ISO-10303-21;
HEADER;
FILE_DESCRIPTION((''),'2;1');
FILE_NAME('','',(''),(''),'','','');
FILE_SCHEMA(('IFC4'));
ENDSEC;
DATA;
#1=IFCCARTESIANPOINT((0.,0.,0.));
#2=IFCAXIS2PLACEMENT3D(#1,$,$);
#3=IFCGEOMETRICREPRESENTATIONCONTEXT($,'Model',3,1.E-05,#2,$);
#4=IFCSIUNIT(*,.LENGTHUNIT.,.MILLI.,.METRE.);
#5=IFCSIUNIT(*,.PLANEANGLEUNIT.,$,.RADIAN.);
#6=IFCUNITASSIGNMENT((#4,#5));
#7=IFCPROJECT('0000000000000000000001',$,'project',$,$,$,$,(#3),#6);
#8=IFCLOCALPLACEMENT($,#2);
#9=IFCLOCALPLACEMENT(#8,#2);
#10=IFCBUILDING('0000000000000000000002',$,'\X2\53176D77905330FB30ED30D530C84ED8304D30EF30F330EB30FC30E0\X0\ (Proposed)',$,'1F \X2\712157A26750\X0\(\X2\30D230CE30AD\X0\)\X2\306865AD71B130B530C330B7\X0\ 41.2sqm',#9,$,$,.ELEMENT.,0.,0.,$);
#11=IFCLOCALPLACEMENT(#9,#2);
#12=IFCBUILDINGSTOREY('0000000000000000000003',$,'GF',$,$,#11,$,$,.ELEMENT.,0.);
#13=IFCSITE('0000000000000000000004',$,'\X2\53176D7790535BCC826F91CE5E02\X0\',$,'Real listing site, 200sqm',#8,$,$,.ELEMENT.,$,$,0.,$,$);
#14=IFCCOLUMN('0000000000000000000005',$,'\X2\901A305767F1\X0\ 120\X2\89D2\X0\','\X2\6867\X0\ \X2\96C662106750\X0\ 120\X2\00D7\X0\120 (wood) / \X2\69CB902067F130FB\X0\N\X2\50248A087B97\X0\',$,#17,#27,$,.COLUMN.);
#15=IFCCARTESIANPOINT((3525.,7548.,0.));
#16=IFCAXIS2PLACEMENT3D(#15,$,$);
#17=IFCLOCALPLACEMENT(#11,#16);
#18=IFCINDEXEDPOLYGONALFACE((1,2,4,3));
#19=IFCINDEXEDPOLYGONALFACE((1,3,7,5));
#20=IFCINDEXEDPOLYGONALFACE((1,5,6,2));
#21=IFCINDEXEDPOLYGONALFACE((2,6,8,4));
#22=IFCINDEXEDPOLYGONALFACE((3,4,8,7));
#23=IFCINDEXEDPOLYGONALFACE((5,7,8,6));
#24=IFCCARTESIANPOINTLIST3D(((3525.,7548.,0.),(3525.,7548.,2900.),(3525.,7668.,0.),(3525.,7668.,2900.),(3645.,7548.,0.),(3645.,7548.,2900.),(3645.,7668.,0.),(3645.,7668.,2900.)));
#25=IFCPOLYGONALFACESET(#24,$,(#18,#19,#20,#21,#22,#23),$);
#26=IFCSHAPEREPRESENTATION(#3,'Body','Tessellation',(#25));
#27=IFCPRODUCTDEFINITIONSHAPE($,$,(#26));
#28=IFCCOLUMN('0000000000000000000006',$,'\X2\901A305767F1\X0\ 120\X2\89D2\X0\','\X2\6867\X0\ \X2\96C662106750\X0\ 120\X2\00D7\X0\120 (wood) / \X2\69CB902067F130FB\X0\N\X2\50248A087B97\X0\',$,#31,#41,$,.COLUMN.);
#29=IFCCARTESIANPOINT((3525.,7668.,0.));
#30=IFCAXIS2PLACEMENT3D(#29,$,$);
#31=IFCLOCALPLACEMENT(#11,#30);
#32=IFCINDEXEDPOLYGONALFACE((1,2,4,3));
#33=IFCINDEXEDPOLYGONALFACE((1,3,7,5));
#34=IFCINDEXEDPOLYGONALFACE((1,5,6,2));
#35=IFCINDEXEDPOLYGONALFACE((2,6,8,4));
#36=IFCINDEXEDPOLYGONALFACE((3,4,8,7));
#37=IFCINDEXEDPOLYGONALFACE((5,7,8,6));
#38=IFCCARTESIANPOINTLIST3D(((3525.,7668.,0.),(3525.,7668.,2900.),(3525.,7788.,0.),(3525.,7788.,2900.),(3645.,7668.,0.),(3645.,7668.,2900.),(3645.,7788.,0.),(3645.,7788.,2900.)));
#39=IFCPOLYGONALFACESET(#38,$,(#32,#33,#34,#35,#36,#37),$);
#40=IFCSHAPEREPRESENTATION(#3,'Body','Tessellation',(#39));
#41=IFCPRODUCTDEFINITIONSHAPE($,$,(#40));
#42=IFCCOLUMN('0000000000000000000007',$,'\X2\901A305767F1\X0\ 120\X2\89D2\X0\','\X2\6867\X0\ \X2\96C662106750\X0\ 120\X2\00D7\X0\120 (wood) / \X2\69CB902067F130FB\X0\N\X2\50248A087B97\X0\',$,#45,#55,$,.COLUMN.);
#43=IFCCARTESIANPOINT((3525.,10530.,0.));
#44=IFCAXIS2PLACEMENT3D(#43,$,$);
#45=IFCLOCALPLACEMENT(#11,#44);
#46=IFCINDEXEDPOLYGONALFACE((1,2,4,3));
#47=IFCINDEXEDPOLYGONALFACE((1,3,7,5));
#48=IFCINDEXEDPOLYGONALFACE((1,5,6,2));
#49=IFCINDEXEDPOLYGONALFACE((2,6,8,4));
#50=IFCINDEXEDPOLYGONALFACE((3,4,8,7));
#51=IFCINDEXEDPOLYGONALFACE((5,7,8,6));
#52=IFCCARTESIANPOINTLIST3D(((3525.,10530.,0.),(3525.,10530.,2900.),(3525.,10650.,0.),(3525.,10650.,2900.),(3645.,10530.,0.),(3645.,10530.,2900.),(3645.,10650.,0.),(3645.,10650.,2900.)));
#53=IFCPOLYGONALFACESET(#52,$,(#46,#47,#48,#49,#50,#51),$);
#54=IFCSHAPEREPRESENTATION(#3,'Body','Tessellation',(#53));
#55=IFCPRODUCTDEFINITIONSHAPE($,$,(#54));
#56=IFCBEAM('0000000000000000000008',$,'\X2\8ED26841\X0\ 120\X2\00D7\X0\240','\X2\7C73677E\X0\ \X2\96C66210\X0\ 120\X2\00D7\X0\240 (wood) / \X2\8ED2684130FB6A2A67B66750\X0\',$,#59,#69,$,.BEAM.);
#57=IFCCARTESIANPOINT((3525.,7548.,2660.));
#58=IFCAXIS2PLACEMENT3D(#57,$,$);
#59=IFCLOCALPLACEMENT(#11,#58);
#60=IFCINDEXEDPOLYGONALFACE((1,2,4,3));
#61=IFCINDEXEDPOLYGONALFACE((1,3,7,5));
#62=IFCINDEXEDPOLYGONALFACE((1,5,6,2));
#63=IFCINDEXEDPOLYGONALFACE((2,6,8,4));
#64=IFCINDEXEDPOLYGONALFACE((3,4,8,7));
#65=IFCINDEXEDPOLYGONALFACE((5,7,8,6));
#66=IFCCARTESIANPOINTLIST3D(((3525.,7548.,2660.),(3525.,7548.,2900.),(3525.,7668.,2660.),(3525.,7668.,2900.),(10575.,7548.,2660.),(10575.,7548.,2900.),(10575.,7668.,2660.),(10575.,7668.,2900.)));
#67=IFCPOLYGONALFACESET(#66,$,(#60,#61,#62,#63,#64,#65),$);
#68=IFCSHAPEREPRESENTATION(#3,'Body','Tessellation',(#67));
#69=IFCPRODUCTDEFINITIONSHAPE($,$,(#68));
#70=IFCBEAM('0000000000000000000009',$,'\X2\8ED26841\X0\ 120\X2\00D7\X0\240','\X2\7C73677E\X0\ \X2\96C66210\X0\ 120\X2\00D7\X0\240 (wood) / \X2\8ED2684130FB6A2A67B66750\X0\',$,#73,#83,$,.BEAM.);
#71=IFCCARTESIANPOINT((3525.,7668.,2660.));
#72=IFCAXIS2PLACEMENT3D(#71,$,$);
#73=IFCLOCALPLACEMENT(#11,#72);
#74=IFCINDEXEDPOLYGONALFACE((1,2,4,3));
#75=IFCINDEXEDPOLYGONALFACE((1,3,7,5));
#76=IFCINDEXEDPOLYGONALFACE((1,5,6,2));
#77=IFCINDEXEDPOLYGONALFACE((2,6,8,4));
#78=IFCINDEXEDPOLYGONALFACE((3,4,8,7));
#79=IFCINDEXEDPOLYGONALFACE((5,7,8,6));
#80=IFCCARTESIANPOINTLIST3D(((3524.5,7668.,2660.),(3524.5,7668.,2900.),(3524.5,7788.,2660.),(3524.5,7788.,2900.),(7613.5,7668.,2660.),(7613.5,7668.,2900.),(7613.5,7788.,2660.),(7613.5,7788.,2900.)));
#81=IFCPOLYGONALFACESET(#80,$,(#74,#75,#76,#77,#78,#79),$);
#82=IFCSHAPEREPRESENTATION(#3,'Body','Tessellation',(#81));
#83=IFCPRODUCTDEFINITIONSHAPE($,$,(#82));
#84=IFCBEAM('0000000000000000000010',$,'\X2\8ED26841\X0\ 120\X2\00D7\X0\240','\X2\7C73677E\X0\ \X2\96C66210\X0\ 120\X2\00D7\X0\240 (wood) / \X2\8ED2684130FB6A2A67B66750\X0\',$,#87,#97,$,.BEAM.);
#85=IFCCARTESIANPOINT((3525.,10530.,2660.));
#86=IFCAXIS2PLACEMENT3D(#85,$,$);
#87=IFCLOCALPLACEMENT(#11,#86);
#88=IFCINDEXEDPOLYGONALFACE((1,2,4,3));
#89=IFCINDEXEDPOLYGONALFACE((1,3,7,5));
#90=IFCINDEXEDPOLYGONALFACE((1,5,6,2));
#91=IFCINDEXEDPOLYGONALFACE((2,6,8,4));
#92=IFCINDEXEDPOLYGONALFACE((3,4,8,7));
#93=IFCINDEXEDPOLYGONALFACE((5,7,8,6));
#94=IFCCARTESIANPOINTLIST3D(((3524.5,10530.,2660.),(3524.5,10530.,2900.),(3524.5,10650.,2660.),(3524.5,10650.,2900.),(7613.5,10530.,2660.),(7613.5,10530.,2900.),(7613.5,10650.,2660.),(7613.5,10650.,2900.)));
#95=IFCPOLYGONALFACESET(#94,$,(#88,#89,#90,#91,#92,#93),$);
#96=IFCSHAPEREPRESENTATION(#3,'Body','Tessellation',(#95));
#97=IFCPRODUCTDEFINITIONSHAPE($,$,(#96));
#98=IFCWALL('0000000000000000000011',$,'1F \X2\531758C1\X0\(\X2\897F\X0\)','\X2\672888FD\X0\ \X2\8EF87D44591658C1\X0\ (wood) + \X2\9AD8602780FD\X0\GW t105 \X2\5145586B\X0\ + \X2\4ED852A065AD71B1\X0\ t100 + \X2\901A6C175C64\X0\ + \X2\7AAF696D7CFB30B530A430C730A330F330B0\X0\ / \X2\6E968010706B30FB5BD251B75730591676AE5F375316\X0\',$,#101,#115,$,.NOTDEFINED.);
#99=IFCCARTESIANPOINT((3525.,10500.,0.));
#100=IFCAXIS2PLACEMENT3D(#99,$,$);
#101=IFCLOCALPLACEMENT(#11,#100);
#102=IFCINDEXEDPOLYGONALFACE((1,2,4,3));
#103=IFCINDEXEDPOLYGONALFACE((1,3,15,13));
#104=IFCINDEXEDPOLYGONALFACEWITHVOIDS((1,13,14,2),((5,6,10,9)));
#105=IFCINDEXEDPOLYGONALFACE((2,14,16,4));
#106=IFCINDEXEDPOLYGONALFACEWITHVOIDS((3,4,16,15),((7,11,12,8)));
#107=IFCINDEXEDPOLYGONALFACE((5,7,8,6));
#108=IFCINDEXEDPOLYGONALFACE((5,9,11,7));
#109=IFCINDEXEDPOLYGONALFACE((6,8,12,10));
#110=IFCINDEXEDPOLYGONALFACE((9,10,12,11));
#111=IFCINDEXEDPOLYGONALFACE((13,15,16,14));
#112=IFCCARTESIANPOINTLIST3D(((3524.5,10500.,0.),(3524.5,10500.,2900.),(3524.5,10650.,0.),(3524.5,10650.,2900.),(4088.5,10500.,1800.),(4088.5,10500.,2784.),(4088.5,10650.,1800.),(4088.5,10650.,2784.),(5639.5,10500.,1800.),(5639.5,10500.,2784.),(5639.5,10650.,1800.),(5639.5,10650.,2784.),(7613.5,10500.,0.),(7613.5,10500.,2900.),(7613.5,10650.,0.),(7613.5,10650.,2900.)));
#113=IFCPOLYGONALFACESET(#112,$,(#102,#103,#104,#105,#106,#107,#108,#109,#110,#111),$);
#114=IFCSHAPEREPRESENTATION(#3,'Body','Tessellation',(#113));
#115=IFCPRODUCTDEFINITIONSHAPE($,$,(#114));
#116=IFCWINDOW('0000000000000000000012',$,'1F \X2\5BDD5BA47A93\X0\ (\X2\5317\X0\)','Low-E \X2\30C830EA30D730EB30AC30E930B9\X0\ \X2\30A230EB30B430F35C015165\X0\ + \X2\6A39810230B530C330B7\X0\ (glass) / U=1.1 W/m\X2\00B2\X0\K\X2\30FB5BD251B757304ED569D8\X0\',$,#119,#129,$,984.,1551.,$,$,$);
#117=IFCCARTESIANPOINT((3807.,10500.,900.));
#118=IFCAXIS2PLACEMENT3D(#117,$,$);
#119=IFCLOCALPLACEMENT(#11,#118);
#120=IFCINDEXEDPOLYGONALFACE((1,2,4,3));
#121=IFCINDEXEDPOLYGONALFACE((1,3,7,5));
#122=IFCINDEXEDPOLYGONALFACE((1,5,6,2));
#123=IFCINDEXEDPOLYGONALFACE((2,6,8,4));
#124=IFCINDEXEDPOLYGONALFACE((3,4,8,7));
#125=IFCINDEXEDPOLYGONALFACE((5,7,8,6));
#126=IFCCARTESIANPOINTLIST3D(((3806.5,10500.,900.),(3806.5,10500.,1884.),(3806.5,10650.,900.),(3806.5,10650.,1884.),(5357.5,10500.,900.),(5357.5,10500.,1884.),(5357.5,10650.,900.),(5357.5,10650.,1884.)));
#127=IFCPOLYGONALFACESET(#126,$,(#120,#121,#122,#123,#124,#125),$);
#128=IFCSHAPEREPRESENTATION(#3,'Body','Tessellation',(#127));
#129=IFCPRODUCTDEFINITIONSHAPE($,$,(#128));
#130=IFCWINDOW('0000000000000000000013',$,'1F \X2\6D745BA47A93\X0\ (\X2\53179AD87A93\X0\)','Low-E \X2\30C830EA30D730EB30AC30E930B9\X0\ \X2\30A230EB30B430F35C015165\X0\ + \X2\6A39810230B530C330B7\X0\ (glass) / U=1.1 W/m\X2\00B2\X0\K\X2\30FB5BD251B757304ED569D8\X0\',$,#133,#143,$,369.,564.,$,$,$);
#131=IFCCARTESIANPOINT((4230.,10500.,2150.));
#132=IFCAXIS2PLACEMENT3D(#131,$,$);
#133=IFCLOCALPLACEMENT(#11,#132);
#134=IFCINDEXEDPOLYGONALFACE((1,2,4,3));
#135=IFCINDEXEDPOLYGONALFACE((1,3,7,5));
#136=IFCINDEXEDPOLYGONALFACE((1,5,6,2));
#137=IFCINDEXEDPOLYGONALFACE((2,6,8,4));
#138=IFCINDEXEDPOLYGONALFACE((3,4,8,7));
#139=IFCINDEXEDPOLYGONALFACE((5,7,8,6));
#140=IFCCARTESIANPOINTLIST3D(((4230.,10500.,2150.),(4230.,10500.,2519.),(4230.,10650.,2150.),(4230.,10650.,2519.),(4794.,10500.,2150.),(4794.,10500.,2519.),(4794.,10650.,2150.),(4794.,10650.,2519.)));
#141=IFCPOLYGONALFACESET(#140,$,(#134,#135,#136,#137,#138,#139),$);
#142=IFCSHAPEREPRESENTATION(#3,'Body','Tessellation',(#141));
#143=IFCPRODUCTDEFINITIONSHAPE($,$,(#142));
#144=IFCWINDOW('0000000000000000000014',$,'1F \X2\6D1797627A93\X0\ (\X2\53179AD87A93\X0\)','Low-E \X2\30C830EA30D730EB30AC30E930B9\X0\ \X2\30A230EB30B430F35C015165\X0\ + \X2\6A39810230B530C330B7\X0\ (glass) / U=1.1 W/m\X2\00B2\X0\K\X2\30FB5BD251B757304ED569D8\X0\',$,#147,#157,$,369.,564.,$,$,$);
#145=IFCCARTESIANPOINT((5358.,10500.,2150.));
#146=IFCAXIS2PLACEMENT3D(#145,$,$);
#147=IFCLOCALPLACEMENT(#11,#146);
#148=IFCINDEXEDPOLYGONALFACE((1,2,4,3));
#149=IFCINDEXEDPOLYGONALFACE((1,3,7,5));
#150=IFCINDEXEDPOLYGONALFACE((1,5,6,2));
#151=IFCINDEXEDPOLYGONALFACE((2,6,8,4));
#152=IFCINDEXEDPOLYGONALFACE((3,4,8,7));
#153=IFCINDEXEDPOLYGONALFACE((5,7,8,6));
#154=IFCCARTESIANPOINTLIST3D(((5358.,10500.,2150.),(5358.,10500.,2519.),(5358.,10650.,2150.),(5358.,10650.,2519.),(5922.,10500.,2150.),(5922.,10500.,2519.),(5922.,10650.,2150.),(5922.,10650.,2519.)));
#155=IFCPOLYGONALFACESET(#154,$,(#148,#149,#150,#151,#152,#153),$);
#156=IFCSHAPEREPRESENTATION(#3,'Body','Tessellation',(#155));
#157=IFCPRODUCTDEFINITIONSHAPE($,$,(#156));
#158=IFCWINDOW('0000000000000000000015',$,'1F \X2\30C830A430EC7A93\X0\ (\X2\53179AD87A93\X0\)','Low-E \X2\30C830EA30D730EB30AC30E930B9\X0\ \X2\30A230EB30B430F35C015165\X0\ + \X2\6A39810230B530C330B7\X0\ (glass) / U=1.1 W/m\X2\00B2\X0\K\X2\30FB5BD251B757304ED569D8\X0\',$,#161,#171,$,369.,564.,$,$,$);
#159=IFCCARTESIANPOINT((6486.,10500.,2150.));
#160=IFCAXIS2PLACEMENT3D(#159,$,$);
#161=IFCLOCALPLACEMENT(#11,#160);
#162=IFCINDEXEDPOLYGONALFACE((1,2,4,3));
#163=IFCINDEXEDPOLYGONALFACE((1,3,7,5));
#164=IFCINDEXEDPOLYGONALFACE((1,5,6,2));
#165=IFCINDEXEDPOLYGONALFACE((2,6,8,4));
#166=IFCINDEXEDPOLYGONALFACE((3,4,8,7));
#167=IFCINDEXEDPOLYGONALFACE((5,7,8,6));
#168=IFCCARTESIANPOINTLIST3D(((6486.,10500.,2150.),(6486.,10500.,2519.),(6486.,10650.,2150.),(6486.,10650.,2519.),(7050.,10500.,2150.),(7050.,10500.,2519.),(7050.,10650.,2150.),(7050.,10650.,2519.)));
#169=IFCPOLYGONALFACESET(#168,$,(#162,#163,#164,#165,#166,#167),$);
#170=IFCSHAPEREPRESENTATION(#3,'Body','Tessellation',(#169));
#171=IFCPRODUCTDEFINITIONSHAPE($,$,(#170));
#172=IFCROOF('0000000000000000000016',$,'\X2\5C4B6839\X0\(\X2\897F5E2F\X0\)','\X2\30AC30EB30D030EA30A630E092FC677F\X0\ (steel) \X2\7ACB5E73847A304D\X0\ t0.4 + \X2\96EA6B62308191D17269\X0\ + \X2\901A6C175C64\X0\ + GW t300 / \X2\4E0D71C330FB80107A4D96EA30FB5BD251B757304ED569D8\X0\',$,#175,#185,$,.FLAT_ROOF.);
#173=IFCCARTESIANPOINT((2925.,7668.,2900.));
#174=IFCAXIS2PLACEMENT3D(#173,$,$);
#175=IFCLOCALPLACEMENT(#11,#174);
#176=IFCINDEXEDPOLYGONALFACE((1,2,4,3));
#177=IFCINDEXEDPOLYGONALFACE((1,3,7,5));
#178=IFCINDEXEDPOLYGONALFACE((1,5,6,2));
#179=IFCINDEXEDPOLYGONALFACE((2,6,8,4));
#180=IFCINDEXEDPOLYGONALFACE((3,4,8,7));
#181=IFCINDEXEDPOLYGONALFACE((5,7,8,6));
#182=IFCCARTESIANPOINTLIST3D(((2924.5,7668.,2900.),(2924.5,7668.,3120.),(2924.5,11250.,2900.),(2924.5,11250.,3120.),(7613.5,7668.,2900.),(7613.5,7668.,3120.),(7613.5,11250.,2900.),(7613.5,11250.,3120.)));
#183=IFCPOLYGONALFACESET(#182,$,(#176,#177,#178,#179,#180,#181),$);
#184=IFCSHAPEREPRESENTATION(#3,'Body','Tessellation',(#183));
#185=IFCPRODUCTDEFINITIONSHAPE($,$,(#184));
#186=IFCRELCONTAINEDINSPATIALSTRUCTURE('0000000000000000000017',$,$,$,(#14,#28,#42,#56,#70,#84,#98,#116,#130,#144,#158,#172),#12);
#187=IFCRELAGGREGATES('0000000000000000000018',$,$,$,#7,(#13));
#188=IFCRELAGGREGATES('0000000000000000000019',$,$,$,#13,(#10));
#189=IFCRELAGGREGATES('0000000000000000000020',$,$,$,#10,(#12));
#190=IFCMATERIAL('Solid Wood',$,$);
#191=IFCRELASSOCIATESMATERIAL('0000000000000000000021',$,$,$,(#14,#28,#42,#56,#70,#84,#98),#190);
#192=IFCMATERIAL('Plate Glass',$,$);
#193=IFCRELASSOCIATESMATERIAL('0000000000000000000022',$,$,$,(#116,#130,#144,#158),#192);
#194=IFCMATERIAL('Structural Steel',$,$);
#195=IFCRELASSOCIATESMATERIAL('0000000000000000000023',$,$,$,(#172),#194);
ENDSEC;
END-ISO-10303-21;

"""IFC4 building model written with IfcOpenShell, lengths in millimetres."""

from ifc_helpers import new_model, si_unit, frame, frame_2d, origin, place, context, project, spatial, rectangle, extrude, material, element, fill, save


model = new_model("IFC4")

# Units and contexts
model_context = context("Model", 3, precision=1e-05, world=origin())
ifc_project = project(units=[si_unit("LENGTHUNIT", "METRE", prefix="MILLI"), si_unit("PLANEANGLEUNIT", "RADIAN")], contexts=[model_context])

# Site, building, storey
site_placement = place(None, origin())
site = spatial("IfcSite", under=ifc_project, at=site_placement, Name="北海道富良野市", ObjectType="Real listing site, 200sqm", CompositionType="ELEMENT", RefElevation=0.0)
building_placement = place(site_placement, origin())
building = spatial("IfcBuilding", under=site, at=building_placement, Name="北海道・ロフト付きワンルーム (Proposed)", ObjectType="1F 無垢材(ヒノキ)と断熱サッシ 41.2sqm", CompositionType="ELEMENT", ElevationOfRefHeight=0.0, ElevationOfTerrain=0.0)
storey_placement = place(building_placement, origin())
storey = spatial("IfcBuildingStorey", under=building, at=storey_placement, Name="GF", CompositionType="ELEMENT", Elevation=0.0)

# Columns
ifc_material_1 = material(Name="Solid Wood")
column_1_placement = place(storey_placement, frame((3525.0, 7548.0, 0.0)))
element("IfcColumn", 1, at=column_1_placement, inside=storey, material=ifc_material_1, Name="通し柱 120角", Description="桧 集成材 120×120 (wood) / 構造柱・N値計算", PredefinedType="COLUMN", context=model_context, shape_type="SweptSolid", body=[
    extrude(rectangle(XDim=120.0, YDim=120.0, at=frame_2d((60.0, 60.0))), frame((3525.0, 7548.0, 0.0)), (0.0, 0.0, 1.0), 2900.0),
])
column_2_placement = place(storey_placement, frame((3525.0, 7668.0, 0.0)))
element("IfcColumn", 2, at=column_2_placement, inside=storey, material=ifc_material_1, Name="通し柱 120角", Description="桧 集成材 120×120 (wood) / 構造柱・N値計算", PredefinedType="COLUMN", context=model_context, shape_type="SweptSolid", body=[
    extrude(rectangle(XDim=120.0, YDim=120.0, at=frame_2d((60.0, 60.0))), frame((3525.0, 7668.0, 0.0)), (0.0, 0.0, 1.0), 2900.0),
])
column_3_placement = place(storey_placement, frame((3525.0, 10530.0, 0.0)))
element("IfcColumn", 3, at=column_3_placement, inside=storey, material=ifc_material_1, Name="通し柱 120角", Description="桧 集成材 120×120 (wood) / 構造柱・N値計算", PredefinedType="COLUMN", context=model_context, shape_type="SweptSolid", body=[
    extrude(rectangle(XDim=120.0, YDim=120.0, at=frame_2d((60.0, 60.0))), frame((3525.0, 10530.0, 0.0)), (0.0, 0.0, 1.0), 2900.0),
])

# Beams
beam_1_placement = place(storey_placement, frame((3525.0, 7548.0, 2660.0)))
element("IfcBeam", 4, at=beam_1_placement, inside=storey, material=ifc_material_1, Name="軒桁 120×240", Description="米松 集成 120×240 (wood) / 軒桁・横架材", PredefinedType="BEAM", context=model_context, shape_type="SweptSolid", body=[
    extrude(rectangle(XDim=7050.0, YDim=120.0, at=frame_2d((3525.0, 60.0))), frame((3525.0, 7548.0, 2660.0)), (0.0, 0.0, 1.0), 240.0),
])
beam_2_placement = place(storey_placement, frame((3525.0, 7668.0, 2660.0)))
element("IfcBeam", 5, at=beam_2_placement, inside=storey, material=ifc_material_1, Name="軒桁 120×240", Description="米松 集成 120×240 (wood) / 軒桁・横架材", PredefinedType="BEAM", context=model_context, shape_type="SweptSolid", body=[
    extrude(rectangle(XDim=4089.0, YDim=120.0, at=frame_2d((2044.0, 60.0))), frame((3525.0, 7668.0, 2660.0)), (0.0, 0.0, 1.0), 240.0),
])
beam_3_placement = place(storey_placement, frame((3525.0, 10530.0, 2660.0)))
element("IfcBeam", 6, at=beam_3_placement, inside=storey, material=ifc_material_1, Name="軒桁 120×240", Description="米松 集成 120×240 (wood) / 軒桁・横架材", PredefinedType="BEAM", context=model_context, shape_type="SweptSolid", body=[
    extrude(rectangle(XDim=4089.0, YDim=120.0, at=frame_2d((2044.0, 60.0))), frame((3525.0, 10530.0, 2660.0)), (0.0, 0.0, 1.0), 240.0),
])

# Wall, openings, windows
wall_1_placement = place(storey_placement, frame((3525.0, 10500.0, 0.0)))
wall_1 = element("IfcWall", 7, at=wall_1_placement, inside=storey, material=ifc_material_1, Name="1F 北壁(西)", Description="木製 軸組外壁 (wood) + 高性能GW t105 充填 + 付加断熱 t100 + 通気層 + 窯業系サイディング / 準耐火・寒冷地外皮強化", PredefinedType="NOTDEFINED", context=model_context, shape_type="SweptSolid", body=[
    extrude(rectangle(XDim=4089.0, YDim=150.0, at=frame_2d((2044.0, 75.0))), frame((3525.0, 10500.0, 0.0)), (0.0, 0.0, 1.0), 2900.0),
])
opening_1_placement = place(storey_placement, frame((3807.0, 10500.0, 900.0)))
opening_1 = element("IfcOpeningElement", 8, at=opening_1_placement, cuts=wall_1, PredefinedType="NOTDEFINED", context=model_context, shape_type="SweptSolid", body=[
    extrude(rectangle(XDim=1551.0, YDim=150.0, at=frame_2d((775.0, 75.0))), frame((3807.0, 10500.0, 900.0)), (0.0, 0.0, 1.0), 984.0),
])
opening_2_placement = place(storey_placement, frame((4230.0, 10500.0, 2150.0)))
opening_2 = element("IfcOpeningElement", 9, at=opening_2_placement, cuts=wall_1, PredefinedType="NOTDEFINED", context=model_context, shape_type="SweptSolid", body=[
    extrude(rectangle(XDim=564.0, YDim=150.0, at=frame_2d((282.0, 75.0))), frame((4230.0, 10500.0, 2150.0)), (0.0, 0.0, 1.0), 369.0),
])
opening_3_placement = place(storey_placement, frame((5358.0, 10500.0, 2150.0)))
opening_3 = element("IfcOpeningElement", 10, at=opening_3_placement, cuts=wall_1, PredefinedType="NOTDEFINED", context=model_context, shape_type="SweptSolid", body=[
    extrude(rectangle(XDim=564.0, YDim=150.0, at=frame_2d((282.0, 75.0))), frame((5358.0, 10500.0, 2150.0)), (0.0, 0.0, 1.0), 369.0),
])
opening_4_placement = place(storey_placement, frame((6486.0, 10500.0, 2150.0)))
opening_4 = element("IfcOpeningElement", 11, at=opening_4_placement, cuts=wall_1, PredefinedType="NOTDEFINED", context=model_context, shape_type="SweptSolid", body=[
    extrude(rectangle(XDim=564.0, YDim=150.0, at=frame_2d((282.0, 75.0))), frame((6486.0, 10500.0, 2150.0)), (0.0, 0.0, 1.0), 369.0),
])
ifc_material_2 = material(Name="Plate Glass")
window_1_placement = place(storey_placement, frame((3807.0, 10500.0, 900.0)))
window_1 = element("IfcWindow", 12, at=window_1_placement, inside=storey, material=ifc_material_2, Name="1F 寝室窓 (北)", Description="Low-E トリプルガラス アルゴン封入 + 樹脂サッシ (glass) / U=1.1 W/m²K・寒冷地仕様", OverallHeight=984.0, OverallWidth=1551.0, context=model_context, shape_type="SweptSolid", body=[
    extrude(rectangle(XDim=1551.0, YDim=150.0, at=frame_2d((775.0, 75.0))), frame((3807.0, 10500.0, 900.0)), (0.0, 0.0, 1.0), 984.0),
])
fill(opening_1, window_1)
window_2_placement = place(storey_placement, frame((4230.0, 10500.0, 2150.0)))
window_2 = element("IfcWindow", 13, at=window_2_placement, inside=storey, material=ifc_material_2, Name="1F 浴室窓 (北高窓)", Description="Low-E トリプルガラス アルゴン封入 + 樹脂サッシ (glass) / U=1.1 W/m²K・寒冷地仕様", OverallHeight=369.0, OverallWidth=564.0, context=model_context, shape_type="SweptSolid", body=[
    extrude(rectangle(XDim=564.0, YDim=150.0, at=frame_2d((282.0, 75.0))), frame((4230.0, 10500.0, 2150.0)), (0.0, 0.0, 1.0), 369.0),
])
fill(opening_2, window_2)
window_3_placement = place(storey_placement, frame((5358.0, 10500.0, 2150.0)))
window_3 = element("IfcWindow", 14, at=window_3_placement, inside=storey, material=ifc_material_2, Name="1F 洗面窓 (北高窓)", Description="Low-E トリプルガラス アルゴン封入 + 樹脂サッシ (glass) / U=1.1 W/m²K・寒冷地仕様", OverallHeight=369.0, OverallWidth=564.0, context=model_context, shape_type="SweptSolid", body=[
    extrude(rectangle(XDim=564.0, YDim=150.0, at=frame_2d((282.0, 75.0))), frame((5358.0, 10500.0, 2150.0)), (0.0, 0.0, 1.0), 369.0),
])
fill(opening_3, window_3)
window_4_placement = place(storey_placement, frame((6486.0, 10500.0, 2150.0)))
window_4 = element("IfcWindow", 15, at=window_4_placement, inside=storey, material=ifc_material_2, Name="1F トイレ窓 (北高窓)", Description="Low-E トリプルガラス アルゴン封入 + 樹脂サッシ (glass) / U=1.1 W/m²K・寒冷地仕様", OverallHeight=369.0, OverallWidth=564.0, context=model_context, shape_type="SweptSolid", body=[
    extrude(rectangle(XDim=564.0, YDim=150.0, at=frame_2d((282.0, 75.0))), frame((6486.0, 10500.0, 2150.0)), (0.0, 0.0, 1.0), 369.0),
])
fill(opening_4, window_4)

# Roof
ifc_material_3 = material(Name="Structural Steel")
roof_placement = place(storey_placement, frame((2925.0, 7668.0, 2900.0)))
element("IfcRoof", 16, at=roof_placement, inside=storey, material=ifc_material_3, Name="屋根(西帯)", Description="ガルバリウム鋼板 (steel) 立平葺き t0.4 + 雪止め金物 + 通気層 + GW t300 / 不燃・耐積雪・寒冷地仕様", PredefinedType="FLAT_ROOF", context=model_context, shape_type="SweptSolid", body=[
    extrude(rectangle(XDim=4689.0, YDim=3582.0, at=frame_2d((2344.0, 1791.0))), frame((2925.0, 7668.0, 2900.0)), (0.0, 0.0, 1.0), 220.0),
])

save(model, "model.ifc")
